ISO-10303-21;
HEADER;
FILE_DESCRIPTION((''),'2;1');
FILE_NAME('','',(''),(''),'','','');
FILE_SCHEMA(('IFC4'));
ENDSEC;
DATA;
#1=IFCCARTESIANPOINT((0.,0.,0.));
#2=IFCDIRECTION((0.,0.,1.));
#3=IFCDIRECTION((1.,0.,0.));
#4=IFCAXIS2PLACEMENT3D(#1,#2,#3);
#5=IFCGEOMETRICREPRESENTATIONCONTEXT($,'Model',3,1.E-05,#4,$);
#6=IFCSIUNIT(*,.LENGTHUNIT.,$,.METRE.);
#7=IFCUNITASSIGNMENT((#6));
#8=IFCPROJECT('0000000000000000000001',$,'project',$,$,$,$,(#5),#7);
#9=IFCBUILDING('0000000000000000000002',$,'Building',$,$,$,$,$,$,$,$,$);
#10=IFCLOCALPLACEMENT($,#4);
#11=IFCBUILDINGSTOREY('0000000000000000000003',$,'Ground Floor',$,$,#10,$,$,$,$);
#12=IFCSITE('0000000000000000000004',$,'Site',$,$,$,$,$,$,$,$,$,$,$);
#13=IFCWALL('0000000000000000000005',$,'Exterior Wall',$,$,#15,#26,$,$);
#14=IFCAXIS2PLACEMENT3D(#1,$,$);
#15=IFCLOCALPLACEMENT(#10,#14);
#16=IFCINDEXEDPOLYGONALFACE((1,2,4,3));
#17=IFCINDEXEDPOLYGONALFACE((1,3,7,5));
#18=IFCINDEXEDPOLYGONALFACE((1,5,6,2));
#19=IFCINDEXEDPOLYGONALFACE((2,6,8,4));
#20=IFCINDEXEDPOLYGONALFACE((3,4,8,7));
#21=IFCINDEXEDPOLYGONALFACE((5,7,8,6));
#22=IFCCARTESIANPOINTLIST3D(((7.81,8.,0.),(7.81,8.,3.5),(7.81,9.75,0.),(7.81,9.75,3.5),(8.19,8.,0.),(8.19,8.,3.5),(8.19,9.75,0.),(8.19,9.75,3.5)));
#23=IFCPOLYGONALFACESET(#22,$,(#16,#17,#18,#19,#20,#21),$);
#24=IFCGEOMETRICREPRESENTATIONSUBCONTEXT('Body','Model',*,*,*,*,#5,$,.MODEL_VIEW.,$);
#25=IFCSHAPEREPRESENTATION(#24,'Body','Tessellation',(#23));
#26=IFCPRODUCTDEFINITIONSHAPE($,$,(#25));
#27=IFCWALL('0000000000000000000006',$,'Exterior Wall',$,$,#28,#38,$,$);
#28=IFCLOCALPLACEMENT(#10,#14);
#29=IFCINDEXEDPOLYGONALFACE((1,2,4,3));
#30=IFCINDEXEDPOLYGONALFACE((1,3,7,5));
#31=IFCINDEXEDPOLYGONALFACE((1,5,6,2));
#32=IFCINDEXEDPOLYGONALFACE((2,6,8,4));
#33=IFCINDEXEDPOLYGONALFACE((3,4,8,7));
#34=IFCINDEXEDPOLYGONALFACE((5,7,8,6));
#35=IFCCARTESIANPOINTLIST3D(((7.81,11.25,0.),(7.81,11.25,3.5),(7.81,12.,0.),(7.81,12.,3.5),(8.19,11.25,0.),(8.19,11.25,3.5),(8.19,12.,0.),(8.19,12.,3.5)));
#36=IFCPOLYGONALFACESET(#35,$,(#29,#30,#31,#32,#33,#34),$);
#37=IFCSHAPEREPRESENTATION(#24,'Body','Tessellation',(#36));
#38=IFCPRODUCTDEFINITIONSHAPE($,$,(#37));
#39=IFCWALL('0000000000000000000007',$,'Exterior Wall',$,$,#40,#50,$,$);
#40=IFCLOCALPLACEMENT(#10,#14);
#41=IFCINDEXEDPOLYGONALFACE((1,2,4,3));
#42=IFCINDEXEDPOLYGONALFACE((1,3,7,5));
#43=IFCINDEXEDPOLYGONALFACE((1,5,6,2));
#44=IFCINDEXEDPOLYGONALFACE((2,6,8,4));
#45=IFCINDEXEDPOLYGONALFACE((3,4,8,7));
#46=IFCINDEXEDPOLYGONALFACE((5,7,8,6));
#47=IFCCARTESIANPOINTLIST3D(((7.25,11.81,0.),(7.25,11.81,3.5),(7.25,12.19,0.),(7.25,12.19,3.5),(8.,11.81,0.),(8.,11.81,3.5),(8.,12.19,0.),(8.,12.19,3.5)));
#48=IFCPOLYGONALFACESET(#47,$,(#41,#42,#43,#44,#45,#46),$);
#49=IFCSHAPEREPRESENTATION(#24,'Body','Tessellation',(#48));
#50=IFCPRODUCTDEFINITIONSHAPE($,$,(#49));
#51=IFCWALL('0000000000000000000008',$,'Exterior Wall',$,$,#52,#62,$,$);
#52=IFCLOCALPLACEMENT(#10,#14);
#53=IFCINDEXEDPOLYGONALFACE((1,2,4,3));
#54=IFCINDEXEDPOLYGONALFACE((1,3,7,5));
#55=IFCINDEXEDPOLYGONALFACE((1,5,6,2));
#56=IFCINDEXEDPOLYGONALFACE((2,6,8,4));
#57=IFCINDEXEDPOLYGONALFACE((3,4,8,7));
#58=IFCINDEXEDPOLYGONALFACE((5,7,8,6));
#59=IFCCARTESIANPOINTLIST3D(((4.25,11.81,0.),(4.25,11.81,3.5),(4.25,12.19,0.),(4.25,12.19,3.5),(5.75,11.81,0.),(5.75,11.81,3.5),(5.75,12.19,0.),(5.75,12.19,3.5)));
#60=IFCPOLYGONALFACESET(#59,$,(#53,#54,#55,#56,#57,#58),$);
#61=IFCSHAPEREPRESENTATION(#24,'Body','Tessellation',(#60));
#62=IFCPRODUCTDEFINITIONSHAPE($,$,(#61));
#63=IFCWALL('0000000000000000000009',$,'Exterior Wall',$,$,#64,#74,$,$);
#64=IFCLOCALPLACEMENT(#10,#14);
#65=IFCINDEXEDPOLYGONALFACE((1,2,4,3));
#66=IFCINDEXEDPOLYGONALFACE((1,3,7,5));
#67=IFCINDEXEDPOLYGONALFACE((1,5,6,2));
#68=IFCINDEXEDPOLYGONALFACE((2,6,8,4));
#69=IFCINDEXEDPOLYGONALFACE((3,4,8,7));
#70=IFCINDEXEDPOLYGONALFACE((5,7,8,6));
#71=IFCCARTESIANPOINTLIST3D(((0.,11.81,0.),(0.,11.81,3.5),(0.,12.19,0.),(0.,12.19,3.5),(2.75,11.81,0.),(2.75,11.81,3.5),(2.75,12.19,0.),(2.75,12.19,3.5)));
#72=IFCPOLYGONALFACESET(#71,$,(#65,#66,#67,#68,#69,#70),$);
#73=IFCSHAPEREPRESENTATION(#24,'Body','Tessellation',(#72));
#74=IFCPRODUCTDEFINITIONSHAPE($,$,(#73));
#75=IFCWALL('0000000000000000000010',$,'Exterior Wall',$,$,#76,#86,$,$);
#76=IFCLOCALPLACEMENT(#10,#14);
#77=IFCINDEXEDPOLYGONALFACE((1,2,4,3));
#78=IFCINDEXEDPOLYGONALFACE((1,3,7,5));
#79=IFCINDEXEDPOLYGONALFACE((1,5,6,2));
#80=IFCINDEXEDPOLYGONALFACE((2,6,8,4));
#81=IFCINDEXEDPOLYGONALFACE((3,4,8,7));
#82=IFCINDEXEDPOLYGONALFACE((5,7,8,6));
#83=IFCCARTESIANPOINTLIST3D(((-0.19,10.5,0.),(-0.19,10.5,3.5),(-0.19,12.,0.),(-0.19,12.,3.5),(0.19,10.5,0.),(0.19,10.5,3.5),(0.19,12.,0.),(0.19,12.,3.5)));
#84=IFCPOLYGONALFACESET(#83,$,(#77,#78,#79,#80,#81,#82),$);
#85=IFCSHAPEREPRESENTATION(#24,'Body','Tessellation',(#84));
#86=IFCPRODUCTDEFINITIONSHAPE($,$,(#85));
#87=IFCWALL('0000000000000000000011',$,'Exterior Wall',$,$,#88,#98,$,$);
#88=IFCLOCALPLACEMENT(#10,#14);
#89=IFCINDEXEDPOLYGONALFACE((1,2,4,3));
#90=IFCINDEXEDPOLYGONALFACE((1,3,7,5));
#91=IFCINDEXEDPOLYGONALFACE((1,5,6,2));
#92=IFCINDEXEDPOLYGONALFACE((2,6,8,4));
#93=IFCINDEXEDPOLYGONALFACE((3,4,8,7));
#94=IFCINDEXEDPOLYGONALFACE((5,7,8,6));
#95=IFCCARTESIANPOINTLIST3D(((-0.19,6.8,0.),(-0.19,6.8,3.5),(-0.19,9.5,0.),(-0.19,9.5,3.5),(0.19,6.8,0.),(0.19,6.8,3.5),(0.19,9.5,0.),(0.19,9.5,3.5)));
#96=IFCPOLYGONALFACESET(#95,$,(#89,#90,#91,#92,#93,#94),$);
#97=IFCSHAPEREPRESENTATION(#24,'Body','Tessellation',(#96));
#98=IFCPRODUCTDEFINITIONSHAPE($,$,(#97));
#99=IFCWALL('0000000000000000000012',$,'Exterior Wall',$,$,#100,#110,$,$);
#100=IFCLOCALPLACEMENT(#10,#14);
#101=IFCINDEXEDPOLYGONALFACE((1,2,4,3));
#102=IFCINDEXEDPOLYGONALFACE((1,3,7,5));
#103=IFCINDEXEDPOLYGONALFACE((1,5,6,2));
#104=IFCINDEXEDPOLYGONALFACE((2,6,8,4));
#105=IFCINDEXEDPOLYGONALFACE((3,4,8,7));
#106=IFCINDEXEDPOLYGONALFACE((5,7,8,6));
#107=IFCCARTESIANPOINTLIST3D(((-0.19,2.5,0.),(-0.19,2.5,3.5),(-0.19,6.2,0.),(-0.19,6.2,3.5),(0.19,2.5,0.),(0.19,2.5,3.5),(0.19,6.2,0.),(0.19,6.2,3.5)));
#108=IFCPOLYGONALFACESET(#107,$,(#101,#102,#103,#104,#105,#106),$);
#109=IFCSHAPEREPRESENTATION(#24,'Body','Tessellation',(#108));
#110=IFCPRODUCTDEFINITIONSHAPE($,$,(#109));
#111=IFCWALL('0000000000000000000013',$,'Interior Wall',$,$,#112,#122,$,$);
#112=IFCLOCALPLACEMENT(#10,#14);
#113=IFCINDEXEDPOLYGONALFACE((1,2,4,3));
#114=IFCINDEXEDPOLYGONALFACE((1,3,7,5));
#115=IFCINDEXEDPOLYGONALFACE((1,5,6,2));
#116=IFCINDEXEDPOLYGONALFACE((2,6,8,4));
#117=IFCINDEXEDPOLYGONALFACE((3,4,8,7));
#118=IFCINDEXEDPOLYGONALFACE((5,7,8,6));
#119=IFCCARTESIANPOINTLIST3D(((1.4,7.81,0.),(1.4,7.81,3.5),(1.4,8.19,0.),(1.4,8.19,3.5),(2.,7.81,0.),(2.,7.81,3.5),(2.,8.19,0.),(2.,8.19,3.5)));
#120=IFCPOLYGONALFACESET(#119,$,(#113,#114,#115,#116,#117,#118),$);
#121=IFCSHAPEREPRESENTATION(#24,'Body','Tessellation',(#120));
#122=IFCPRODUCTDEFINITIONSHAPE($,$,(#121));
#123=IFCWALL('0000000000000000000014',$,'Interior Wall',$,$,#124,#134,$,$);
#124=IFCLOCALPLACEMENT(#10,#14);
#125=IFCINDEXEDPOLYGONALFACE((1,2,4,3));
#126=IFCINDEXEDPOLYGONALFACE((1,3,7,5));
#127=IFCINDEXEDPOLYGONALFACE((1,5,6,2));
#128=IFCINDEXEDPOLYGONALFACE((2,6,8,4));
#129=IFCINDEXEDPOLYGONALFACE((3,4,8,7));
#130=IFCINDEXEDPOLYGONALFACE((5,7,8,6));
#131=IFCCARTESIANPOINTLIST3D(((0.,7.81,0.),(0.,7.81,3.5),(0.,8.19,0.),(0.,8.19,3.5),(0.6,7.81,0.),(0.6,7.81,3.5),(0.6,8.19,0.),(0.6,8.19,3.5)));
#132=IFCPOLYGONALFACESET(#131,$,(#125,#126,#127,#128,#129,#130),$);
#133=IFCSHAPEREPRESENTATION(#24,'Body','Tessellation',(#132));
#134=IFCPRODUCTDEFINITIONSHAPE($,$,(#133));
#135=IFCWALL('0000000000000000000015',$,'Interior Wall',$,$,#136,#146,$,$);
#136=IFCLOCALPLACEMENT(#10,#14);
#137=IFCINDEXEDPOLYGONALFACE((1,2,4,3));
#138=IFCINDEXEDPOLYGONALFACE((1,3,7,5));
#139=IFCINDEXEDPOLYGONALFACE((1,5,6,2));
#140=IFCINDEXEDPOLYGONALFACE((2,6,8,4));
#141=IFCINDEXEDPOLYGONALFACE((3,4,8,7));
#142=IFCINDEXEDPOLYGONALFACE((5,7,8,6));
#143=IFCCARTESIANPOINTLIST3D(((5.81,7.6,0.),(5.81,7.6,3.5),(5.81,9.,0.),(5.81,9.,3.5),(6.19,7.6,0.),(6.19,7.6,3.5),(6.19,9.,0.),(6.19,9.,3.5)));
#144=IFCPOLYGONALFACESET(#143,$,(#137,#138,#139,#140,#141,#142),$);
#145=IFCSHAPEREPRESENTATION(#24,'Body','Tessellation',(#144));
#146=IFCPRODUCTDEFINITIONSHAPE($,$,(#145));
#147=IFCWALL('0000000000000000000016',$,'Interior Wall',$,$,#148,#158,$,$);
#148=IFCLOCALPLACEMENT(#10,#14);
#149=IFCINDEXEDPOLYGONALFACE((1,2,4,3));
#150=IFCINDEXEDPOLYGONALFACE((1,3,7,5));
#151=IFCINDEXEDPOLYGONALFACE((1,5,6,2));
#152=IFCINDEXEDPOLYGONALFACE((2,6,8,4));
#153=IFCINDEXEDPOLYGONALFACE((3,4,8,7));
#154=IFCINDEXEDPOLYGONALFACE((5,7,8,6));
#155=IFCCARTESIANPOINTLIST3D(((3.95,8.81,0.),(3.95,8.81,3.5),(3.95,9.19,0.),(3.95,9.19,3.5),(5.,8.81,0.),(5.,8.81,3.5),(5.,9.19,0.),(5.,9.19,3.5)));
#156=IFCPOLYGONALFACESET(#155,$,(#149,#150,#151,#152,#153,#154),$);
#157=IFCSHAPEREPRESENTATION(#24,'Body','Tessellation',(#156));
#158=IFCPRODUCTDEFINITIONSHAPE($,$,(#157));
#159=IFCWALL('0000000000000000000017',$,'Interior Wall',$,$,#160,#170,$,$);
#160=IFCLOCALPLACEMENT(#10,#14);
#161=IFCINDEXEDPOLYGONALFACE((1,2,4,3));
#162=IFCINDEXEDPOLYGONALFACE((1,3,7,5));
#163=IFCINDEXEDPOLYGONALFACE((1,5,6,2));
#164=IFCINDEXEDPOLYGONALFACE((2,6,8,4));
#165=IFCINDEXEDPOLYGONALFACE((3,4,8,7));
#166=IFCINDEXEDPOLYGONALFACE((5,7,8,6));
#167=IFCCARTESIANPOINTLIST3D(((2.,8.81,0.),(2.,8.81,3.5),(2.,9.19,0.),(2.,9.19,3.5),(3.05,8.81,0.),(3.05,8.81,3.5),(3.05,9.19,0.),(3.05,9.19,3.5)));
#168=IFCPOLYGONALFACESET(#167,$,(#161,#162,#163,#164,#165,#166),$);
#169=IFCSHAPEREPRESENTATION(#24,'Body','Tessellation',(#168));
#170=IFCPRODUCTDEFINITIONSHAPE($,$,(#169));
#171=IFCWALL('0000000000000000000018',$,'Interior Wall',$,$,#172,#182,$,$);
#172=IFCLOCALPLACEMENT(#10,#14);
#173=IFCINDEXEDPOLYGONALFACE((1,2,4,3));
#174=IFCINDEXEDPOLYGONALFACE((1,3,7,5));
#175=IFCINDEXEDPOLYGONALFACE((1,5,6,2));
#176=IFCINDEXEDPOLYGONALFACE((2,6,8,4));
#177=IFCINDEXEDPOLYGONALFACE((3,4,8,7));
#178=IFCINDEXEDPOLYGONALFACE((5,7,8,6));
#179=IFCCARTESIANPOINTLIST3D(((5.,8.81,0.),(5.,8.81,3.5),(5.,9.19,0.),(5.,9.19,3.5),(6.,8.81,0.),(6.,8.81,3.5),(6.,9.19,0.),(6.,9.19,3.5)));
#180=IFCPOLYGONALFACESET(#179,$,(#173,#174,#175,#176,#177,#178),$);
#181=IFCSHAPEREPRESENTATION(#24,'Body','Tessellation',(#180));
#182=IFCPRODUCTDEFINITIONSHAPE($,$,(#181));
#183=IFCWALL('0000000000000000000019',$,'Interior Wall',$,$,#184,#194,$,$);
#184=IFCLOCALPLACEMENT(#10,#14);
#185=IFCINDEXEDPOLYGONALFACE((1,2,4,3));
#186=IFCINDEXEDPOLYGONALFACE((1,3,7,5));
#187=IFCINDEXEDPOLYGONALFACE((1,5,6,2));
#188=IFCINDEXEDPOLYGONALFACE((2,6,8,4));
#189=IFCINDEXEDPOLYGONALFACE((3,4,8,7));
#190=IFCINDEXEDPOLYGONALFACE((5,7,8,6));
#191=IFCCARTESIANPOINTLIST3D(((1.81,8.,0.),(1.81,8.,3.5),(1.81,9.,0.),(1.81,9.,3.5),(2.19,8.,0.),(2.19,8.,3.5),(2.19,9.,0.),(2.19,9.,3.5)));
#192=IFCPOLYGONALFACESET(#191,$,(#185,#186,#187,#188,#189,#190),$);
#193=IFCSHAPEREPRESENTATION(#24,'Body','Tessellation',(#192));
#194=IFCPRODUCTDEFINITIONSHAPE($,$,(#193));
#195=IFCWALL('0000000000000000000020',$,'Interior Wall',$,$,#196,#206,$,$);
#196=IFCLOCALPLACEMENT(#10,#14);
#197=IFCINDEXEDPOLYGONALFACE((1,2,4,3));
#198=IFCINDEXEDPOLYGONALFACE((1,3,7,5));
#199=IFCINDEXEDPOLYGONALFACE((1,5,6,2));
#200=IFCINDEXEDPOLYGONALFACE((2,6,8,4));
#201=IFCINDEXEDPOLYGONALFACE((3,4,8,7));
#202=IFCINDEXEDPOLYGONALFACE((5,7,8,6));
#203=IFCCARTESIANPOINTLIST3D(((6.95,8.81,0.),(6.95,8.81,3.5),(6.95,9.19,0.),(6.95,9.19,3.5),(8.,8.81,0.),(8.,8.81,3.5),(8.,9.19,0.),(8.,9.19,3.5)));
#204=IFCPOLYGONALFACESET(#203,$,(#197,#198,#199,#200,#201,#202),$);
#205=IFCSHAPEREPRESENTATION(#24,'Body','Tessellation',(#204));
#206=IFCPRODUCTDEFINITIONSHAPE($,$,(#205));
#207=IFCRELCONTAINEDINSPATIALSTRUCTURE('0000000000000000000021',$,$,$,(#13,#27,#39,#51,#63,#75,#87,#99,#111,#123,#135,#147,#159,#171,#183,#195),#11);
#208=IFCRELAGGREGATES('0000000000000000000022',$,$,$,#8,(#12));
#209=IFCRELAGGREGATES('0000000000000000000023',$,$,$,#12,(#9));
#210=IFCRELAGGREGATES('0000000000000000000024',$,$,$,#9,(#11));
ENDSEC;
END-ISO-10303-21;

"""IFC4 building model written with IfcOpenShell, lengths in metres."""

from ifc_helpers import new_model, si_unit, frame, origin_with_axes, place, context, subcontext, project, spatial, indexed_curve, outline, extrude, element, save


model = new_model("IFC4")

# Units and contexts
model_context = context("Model", 3, precision=1e-05, world=origin_with_axes())
body_context = subcontext(model_context, "Body", "Model", "MODEL_VIEW")
ifc_project = project(units=[si_unit("LENGTHUNIT", "METRE")], contexts=[model_context])

# Site, building, storey
site = spatial("IfcSite", under=ifc_project, Name="Site")
building = spatial("IfcBuilding", under=site, Name="Building")
storey_placement = place(None, origin_with_axes())
storey = spatial("IfcBuildingStorey", under=building, at=storey_placement, Name="Ground Floor")

# Walls
wall_1_placement = place(storey_placement, frame((8.0, 8.0, 0.0), z_axis=(0.0, 0.0, 1.0), x_axis=(0.0, 1.0, 0.0)))
element("IfcWall", 1, at=wall_1_placement, inside=storey, Name="Exterior Wall", context=body_context, shape_type="SweptSolid", body=[
    extrude(outline(indexed_curve([(0.0, 0.0), (0.0, 0.38), (1.75, 0.38), (1.75, 0.0), (0.0, 0.0)], self_intersect=False)), frame((0.0, -0.19, 0.0), z_axis=(0.0, 0.0, 1.0), x_axis=(1.0, 0.0, 0.0)), (0.0, 0.0, 1.0), 3.5),
])
for number, where, z_axis, x_axis, name in (
    (2, (8.0, 11.25, 0.0), (0.0, 0.0, 1.0), (0.0, 1.0, 0.0), "Exterior Wall"),
    (3, (8.0, 12.0, 0.0), (0.0, 0.0, 1.0), (-1.0, 0.0, 0.0), "Exterior Wall"),
):
    element("IfcWall", number, at=place(storey_placement, frame(where, z_axis=z_axis, x_axis=x_axis)), inside=storey, Name=name, context=body_context, shape_type="SweptSolid", body=[
        extrude(outline(indexed_curve([(0.0, 0.0), (0.0, 0.38), (0.75, 0.38), (0.75, 0.0), (0.0, 0.0)], self_intersect=False)), frame((0.0, -0.19, 0.0), z_axis=(0.0, 0.0, 1.0), x_axis=(1.0, 0.0, 0.0)), (0.0, 0.0, 1.0), 3.5),
    ])
wall_2_placement = place(storey_placement, frame((5.75, 12.0, 0.0), z_axis=(0.0, 0.0, 1.0), x_axis=(-1.0, 0.0, 0.0)))
element("IfcWall", 4, at=wall_2_placement, inside=storey, Name="Exterior Wall", context=body_context, shape_type="SweptSolid", body=[
    extrude(outline(indexed_curve([(0.0, 0.0), (0.0, 0.38), (1.5, 0.38), (1.5, 0.0), (0.0, 0.0)], self_intersect=False)), frame((0.0, -0.19, 0.0), z_axis=(0.0, 0.0, 1.0), x_axis=(1.0, 0.0, 0.0)), (0.0, 0.0, 1.0), 3.5),
])
wall_3_placement = place(storey_placement, frame((2.75, 12.0, 0.0), z_axis=(0.0, 0.0, 1.0), x_axis=(-1.0, 0.0, 0.0)))
element("IfcWall", 5, at=wall_3_placement, inside=storey, Name="Exterior Wall", context=body_context, shape_type="SweptSolid", body=[
    extrude(outline(indexed_curve([(0.0, 0.0), (0.0, 0.38), (2.75, 0.38), (2.75, 0.0), (0.0, 0.0)], self_intersect=False)), frame((0.0, -0.19, 0.0), z_axis=(0.0, 0.0, 1.0), x_axis=(1.0, 0.0, 0.0)), (0.0, 0.0, 1.0), 3.5),
])
wall_4_placement = place(storey_placement, frame((0.0, 12.0, 0.0), z_axis=(0.0, 0.0, 1.0), x_axis=(0.0, -1.0, 0.0)))
element("IfcWall", 6, at=wall_4_placement, inside=storey, Name="Exterior Wall", context=body_context, shape_type="SweptSolid", body=[
    extrude(outline(indexed_curve([(0.0, 0.0), (0.0, 0.38), (1.5, 0.38), (1.5, 0.0), (0.0, 0.0)], self_intersect=False)), frame((0.0, -0.19, 0.0), z_axis=(0.0, 0.0, 1.0), x_axis=(1.0, 0.0, 0.0)), (0.0, 0.0, 1.0), 3.5),
])
wall_5_placement = place(storey_placement, frame((0.0, 9.5, 0.0), z_axis=(0.0, 0.0, 1.0), x_axis=(0.0, -1.0, 0.0)))
element("IfcWall", 7, at=wall_5_placement, inside=storey, Name="Exterior Wall", context=body_context, shape_type="SweptSolid", body=[
    extrude(outline(indexed_curve([(0.0, 0.0), (0.0, 0.38), (2.7, 0.38), (2.7, 0.0), (0.0, 0.0)], self_intersect=False)), frame((0.0, -0.19, 0.0), z_axis=(0.0, 0.0, 1.0), x_axis=(1.0, 0.0, 0.0)), (0.0, 0.0, 1.0), 3.5),
])
wall_6_placement = place(storey_placement, frame((0.0, 6.2, 0.0), z_axis=(0.0, 0.0, 1.0), x_axis=(0.0, -1.0, 0.0)))
element("IfcWall", 8, at=wall_6_placement, inside=storey, Name="Exterior Wall", context=body_context, shape_type="SweptSolid", body=[
    extrude(outline(indexed_curve([(0.0, 0.0), (0.0, 0.38), (3.7, 0.38), (3.7, 0.0), (0.0, 0.0)], self_intersect=False)), frame((0.0, -0.19, 0.0), z_axis=(0.0, 0.0, 1.0), x_axis=(1.0, 0.0, 0.0)), (0.0, 0.0, 1.0), 3.5),
])
for number, where, z_axis, x_axis, name in (
    (9, (2.0, 8.0, 0.0), (0.0, 0.0, 1.0), (-1.0, 0.0, 0.0), "Interior Wall"),
    (10, (0.6, 8.0, 0.0), (0.0, 0.0, 1.0), (-1.0, 0.0, 0.0), "Interior Wall"),
):
    element("IfcWall", number, at=place(storey_placement, frame(where, z_axis=z_axis, x_axis=x_axis)), inside=storey, Name=name, context=body_context, shape_type="SweptSolid", body=[
        extrude(outline(indexed_curve([(0.0, 0.0), (0.0, 0.38), (0.6, 0.38), (0.6, 0.0), (0.0, 0.0)], self_intersect=False)), frame((0.0, -0.19, 0.0), z_axis=(0.0, 0.0, 1.0), x_axis=(1.0, 0.0, 0.0)), (0.0, 0.0, 1.0), 3.5),
    ])
wall_7_placement = place(storey_placement, frame((6.0, 7.6, 0.0), z_axis=(0.0, 0.0, 1.0), x_axis=(0.0, 1.0, 0.0)))
element("IfcWall", 11, at=wall_7_placement, inside=storey, Name="Interior Wall", context=body_context, shape_type="SweptSolid", body=[
    extrude(outline(indexed_curve([(0.0, 0.0), (0.0, 0.38), (1.4, 0.38), (1.4, 0.0), (0.0, 0.0)], self_intersect=False)), frame((0.0, -0.19, 0.0), z_axis=(0.0, 0.0, 1.0), x_axis=(1.0, 0.0, 0.0)), (0.0, 0.0, 1.0), 3.5),
])
for number, where, z_axis, x_axis, name in (
    (12, (5.0, 9.0, 0.0), (0.0, 0.0, 1.0), (-1.0, 0.0, 0.0), "Interior Wall"),
    (13, (3.05, 9.0, 0.0), (0.0, 0.0, 1.0), (-1.0, 0.0, 0.0), "Interior Wall"),
):
    element("IfcWall", number, at=place(storey_placement, frame(where, z_axis=z_axis, x_axis=x_axis)), inside=storey, Name=name, context=body_context, shape_type="SweptSolid", body=[
        extrude(outline(indexed_curve([(0.0, 0.0), (0.0, 0.38), (1.05, 0.38), (1.05, 0.0), (0.0, 0.0)], self_intersect=False)), frame((0.0, -0.19, 0.0), z_axis=(0.0, 0.0, 1.0), x_axis=(1.0, 0.0, 0.0)), (0.0, 0.0, 1.0), 3.5),
    ])
for number, where, z_axis, x_axis, name in (
    (14, (6.0, 9.0, 0.0), (0.0, 0.0, 1.0), (-1.0, 0.0, 0.0), "Interior Wall"),
    (15, (2.0, 9.0, 0.0), (0.0, 0.0, 1.0), (0.0, -1.0, 0.0), "Interior Wall"),
):
    element("IfcWall", number, at=place(storey_placement, frame(where, z_axis=z_axis, x_axis=x_axis)), inside=storey, Name=name, context=body_context, shape_type="SweptSolid", body=[
        extrude(outline(indexed_curve([(0.0, 0.0), (0.0, 0.38), (1.0, 0.38), (1.0, 0.0), (0.0, 0.0)], self_intersect=False)), frame((0.0, -0.19, 0.0), z_axis=(0.0, 0.0, 1.0), x_axis=(1.0, 0.0, 0.0)), (0.0, 0.0, 1.0), 3.5),
    ])
wall_8_placement = place(storey_placement, frame((8.0, 9.0, 0.0), z_axis=(0.0, 0.0, 1.0), x_axis=(-1.0, 0.0, 0.0)))
element("IfcWall", 16, at=wall_8_placement, inside=storey, Name="Interior Wall", context=body_context, shape_type="SweptSolid", body=[
    extrude(outline(indexed_curve([(0.0, 0.0), (0.0, 0.38), (1.05, 0.38), (1.05, 0.0), (0.0, 0.0)], self_intersect=False)), frame((0.0, -0.19, 0.0), z_axis=(0.0, 0.0, 1.0), x_axis=(1.0, 0.0, 0.0)), (0.0, 0.0, 1.0), 3.5),
])

save(model, "model.ifc")
